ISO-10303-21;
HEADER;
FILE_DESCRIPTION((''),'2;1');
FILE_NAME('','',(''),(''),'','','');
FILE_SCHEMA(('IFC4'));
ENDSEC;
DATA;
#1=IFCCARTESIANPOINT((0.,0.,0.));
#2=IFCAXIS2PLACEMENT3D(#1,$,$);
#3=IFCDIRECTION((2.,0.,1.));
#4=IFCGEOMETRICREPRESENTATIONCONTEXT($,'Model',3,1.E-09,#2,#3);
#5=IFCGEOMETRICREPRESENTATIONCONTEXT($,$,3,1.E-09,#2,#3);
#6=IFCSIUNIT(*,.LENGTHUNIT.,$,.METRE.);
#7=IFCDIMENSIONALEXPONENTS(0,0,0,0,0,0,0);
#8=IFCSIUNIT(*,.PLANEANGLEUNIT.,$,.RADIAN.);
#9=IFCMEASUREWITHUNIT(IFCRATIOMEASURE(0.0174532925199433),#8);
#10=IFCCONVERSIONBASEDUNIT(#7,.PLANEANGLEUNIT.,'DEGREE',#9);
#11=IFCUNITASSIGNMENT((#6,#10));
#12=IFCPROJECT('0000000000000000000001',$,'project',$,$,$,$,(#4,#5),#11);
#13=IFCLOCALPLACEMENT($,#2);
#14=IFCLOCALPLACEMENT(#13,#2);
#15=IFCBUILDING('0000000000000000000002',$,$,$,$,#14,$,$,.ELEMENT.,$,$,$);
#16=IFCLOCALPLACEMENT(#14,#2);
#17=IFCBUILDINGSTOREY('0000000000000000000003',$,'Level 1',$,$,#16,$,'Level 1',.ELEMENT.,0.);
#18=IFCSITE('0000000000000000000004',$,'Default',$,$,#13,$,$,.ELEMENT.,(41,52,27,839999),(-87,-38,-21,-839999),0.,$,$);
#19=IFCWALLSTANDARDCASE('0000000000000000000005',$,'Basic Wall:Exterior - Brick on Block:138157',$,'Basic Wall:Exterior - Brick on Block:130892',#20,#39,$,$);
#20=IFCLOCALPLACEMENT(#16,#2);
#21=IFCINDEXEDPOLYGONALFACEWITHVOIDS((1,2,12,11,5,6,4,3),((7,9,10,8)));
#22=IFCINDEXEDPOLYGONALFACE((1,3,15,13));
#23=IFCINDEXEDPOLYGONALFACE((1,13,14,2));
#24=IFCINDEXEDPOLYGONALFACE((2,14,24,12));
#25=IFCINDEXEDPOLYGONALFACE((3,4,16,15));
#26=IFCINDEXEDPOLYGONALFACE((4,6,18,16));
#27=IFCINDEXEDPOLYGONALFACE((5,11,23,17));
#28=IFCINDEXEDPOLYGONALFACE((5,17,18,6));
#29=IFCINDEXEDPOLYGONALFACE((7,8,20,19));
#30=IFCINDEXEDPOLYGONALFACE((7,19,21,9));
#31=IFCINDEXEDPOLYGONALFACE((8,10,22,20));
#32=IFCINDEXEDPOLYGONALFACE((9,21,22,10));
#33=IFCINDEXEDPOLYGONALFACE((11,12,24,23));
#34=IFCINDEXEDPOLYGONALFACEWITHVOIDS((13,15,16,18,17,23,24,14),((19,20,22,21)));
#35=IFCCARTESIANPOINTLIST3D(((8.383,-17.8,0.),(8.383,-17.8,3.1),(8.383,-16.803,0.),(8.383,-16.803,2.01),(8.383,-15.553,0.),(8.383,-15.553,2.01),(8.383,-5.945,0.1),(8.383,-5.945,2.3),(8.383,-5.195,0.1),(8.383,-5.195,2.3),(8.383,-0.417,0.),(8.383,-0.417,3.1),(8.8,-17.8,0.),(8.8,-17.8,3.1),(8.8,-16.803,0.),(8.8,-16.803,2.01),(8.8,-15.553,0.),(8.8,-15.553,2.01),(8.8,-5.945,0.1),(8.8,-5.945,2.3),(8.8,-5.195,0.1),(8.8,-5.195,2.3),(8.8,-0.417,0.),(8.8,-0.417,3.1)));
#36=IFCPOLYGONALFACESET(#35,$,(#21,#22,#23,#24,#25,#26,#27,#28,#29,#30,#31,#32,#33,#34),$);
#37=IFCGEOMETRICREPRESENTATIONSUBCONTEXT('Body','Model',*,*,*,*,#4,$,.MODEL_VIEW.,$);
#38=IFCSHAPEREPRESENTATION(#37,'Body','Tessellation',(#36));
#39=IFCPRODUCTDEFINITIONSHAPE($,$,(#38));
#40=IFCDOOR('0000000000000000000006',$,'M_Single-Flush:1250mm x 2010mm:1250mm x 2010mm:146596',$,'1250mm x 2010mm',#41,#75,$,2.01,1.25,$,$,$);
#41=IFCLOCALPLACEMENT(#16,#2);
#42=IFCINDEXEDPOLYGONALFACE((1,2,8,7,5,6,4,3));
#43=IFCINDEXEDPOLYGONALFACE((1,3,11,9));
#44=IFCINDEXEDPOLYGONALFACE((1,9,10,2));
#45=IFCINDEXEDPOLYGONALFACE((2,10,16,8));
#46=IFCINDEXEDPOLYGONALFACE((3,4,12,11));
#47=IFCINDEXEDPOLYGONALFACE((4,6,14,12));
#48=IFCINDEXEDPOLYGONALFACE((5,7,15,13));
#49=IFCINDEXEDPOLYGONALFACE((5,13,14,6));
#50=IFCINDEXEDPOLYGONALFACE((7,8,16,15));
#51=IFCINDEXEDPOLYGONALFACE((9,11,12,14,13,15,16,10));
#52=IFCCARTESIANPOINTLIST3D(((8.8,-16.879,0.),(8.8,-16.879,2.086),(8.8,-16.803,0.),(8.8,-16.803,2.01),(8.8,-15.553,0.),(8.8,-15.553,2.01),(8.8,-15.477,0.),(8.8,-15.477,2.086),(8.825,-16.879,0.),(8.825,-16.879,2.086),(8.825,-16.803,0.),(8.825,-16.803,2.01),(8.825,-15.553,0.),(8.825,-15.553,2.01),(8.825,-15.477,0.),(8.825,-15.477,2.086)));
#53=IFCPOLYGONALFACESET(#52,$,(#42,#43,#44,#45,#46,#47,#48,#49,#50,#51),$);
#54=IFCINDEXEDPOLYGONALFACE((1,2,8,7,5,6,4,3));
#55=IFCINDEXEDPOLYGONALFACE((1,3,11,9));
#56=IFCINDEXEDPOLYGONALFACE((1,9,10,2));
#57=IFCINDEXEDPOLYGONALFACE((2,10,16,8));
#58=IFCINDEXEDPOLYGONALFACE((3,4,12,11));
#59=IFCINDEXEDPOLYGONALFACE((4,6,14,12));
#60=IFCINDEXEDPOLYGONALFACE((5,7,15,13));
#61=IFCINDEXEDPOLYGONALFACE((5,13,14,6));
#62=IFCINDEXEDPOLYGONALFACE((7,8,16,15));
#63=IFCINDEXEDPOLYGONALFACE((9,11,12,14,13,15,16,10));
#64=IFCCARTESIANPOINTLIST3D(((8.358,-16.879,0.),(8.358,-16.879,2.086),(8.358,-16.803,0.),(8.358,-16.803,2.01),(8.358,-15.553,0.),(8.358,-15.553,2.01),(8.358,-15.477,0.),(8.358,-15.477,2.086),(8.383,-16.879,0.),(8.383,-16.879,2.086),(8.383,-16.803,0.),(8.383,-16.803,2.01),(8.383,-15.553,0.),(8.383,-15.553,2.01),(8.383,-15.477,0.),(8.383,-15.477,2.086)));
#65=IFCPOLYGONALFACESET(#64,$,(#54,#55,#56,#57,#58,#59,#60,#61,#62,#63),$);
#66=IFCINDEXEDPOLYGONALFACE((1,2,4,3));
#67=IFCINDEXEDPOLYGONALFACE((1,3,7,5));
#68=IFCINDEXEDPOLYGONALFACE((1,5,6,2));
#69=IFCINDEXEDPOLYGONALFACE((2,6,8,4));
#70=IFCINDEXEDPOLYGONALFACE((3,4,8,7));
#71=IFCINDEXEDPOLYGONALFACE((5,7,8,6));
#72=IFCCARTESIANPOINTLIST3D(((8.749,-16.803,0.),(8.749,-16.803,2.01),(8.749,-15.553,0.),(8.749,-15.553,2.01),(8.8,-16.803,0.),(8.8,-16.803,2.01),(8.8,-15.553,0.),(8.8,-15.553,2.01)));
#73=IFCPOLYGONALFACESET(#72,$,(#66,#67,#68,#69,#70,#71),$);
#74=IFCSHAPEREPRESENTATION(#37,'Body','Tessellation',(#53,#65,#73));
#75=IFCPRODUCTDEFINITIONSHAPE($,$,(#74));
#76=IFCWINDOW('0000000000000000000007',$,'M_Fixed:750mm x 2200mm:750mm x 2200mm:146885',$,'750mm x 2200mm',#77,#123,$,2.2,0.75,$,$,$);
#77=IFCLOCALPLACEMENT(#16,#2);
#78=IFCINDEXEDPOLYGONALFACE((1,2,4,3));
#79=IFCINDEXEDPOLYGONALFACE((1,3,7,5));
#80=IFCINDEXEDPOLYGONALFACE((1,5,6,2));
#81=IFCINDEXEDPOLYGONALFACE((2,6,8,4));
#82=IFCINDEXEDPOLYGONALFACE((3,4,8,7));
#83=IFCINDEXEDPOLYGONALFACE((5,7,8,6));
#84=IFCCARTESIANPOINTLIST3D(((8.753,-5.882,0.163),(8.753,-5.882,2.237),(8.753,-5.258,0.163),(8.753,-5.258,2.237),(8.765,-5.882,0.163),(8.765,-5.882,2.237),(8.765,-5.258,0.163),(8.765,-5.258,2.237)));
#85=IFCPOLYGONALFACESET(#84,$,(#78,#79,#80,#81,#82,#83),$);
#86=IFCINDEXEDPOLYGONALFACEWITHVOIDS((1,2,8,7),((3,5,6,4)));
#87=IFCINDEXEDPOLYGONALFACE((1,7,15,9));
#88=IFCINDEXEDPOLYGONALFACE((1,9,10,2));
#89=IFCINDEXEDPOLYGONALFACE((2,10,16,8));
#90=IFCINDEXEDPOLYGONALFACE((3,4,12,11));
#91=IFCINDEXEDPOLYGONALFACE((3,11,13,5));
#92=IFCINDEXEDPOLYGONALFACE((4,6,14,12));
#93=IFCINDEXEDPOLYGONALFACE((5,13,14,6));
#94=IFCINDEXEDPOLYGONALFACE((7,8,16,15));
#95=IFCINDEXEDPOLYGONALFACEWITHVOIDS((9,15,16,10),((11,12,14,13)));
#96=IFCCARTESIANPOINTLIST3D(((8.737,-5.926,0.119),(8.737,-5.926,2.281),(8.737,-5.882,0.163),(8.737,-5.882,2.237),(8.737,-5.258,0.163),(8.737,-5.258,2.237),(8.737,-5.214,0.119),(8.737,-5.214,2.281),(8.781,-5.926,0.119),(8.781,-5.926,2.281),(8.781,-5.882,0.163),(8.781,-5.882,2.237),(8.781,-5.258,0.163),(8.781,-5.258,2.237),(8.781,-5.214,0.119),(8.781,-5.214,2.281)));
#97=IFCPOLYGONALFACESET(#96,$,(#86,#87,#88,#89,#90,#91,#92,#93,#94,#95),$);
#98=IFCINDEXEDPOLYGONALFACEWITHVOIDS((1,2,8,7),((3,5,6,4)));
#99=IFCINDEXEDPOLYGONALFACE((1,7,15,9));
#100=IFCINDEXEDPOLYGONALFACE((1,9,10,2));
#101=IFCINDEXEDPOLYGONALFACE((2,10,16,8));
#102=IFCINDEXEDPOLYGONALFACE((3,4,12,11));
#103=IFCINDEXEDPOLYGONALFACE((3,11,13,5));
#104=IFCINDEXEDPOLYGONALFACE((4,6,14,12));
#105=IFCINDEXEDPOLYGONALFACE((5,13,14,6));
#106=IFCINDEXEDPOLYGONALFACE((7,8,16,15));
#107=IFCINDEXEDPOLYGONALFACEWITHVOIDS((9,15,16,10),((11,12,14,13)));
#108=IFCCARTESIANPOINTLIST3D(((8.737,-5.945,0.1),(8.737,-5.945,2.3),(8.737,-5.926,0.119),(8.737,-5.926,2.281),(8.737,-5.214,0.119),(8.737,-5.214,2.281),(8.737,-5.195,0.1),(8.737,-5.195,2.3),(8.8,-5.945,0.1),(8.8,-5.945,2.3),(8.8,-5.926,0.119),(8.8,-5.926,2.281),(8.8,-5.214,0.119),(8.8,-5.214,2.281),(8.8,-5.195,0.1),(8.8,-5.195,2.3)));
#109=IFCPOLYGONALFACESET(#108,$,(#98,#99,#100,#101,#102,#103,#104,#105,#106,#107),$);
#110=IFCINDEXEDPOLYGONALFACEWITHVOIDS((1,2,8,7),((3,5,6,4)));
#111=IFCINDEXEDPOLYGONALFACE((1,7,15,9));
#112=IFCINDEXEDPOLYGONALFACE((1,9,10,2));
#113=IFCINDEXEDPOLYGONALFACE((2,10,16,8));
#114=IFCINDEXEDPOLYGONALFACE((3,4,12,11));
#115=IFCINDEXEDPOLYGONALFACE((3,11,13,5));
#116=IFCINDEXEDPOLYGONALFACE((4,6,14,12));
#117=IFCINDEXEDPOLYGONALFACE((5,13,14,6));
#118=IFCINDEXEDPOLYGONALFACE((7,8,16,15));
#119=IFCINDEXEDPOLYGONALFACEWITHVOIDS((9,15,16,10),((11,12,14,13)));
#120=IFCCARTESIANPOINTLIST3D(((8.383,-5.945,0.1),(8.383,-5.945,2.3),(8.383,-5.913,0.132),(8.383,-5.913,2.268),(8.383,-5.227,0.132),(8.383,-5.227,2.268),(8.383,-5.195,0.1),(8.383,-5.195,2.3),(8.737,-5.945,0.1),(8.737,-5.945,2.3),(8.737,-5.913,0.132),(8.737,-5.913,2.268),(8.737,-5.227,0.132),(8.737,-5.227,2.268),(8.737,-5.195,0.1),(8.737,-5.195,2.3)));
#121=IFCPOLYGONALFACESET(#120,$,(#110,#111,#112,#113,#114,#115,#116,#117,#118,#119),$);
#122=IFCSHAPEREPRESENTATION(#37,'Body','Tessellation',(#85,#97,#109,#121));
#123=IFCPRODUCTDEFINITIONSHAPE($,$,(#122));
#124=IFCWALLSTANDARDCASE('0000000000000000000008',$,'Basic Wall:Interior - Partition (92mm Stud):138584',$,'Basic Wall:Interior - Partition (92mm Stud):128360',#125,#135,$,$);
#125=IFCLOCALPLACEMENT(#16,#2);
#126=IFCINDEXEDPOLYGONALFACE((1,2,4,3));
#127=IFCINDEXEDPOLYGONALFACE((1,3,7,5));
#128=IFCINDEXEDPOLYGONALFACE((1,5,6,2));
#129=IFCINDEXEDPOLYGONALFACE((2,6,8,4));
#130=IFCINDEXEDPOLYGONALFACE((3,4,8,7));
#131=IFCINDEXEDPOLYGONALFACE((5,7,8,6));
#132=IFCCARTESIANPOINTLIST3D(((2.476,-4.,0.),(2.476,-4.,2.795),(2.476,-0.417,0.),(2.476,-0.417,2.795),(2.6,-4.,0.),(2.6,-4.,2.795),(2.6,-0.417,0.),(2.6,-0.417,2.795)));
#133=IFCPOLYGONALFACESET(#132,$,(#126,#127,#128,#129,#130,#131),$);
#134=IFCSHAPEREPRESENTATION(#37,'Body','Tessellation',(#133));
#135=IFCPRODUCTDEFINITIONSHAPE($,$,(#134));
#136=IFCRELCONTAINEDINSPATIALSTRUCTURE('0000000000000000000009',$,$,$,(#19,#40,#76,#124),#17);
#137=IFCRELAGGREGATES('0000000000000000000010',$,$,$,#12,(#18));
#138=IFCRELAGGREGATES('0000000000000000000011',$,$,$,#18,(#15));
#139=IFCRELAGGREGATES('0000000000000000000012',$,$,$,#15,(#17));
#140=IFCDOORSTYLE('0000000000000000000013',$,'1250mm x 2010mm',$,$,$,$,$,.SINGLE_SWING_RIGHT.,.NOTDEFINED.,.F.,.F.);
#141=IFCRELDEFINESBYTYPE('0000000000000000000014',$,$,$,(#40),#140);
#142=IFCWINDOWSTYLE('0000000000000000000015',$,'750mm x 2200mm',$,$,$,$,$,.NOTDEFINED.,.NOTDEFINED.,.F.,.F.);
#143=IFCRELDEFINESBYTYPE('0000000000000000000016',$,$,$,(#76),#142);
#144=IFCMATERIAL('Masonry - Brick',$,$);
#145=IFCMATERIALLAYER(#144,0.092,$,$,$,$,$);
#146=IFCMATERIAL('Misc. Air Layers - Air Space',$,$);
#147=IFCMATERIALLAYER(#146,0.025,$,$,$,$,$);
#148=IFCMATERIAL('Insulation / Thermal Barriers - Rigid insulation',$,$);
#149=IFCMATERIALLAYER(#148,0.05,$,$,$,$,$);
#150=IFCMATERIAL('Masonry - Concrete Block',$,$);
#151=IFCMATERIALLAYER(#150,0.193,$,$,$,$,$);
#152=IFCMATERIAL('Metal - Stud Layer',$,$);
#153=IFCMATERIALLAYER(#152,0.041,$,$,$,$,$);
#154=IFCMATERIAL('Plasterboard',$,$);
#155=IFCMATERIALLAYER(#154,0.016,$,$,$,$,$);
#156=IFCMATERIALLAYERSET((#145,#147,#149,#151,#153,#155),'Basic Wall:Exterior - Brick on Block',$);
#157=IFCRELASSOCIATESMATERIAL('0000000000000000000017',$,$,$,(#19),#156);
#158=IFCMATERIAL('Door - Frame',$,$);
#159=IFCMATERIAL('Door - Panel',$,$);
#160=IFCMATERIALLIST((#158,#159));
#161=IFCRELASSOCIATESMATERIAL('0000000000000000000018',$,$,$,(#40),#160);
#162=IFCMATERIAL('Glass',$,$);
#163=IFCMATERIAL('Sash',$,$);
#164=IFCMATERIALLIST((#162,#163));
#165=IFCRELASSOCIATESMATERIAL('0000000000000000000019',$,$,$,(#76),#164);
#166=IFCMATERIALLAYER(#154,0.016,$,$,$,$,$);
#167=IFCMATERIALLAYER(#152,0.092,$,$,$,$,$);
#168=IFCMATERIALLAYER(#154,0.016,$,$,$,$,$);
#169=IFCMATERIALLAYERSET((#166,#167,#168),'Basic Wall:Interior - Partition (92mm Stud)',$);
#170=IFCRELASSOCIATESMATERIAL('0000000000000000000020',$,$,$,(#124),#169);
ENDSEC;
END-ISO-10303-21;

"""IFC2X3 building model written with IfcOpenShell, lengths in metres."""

from ifc_helpers import new_model, entity, si_unit, converted_unit, direction, frame, frame_2d, origin, origin_2d_with_axis, place, context, subcontext, project, spatial, polyline, rectangle, outline, extrude, source, transform, mapped, material, material_list, layer, layer_set, layer_usage, type_object, type_shapes, element, fill, save


model = new_model("IFC2X3")

# Units and contexts
model_context = context("Model", 3, precision=1e-09, world=origin(), true_north=direction((2.0, 0.0, 1.0)))
context_of_model = context(None, 3, precision=1e-09, world=origin(), true_north=direction((2.0, 0.0, 1.0)))
body_context = subcontext(model_context, "Body", "Model", "MODEL_VIEW")
ifc_project = project(units=[si_unit("LENGTHUNIT", "METRE"), converted_unit("PLANEANGLEUNIT", "DEGREE", entity("IfcRatioMeasure", 0.0174532925199433), si_unit("PLANEANGLEUNIT", "RADIAN"), dimensions=[0, 0, 0, 0, 0, 0, 0])], contexts=[model_context, context_of_model])

# Site, building, storey
site_placement = place(None, origin())
site = spatial("IfcSite", under=ifc_project, at=site_placement, Name="Default", CompositionType="ELEMENT", RefLatitude=(41, 52, 27, 839999), RefLongitude=(-87, -38, -21, -839999), RefElevation=0.0)
building_placement = place(site_placement, origin())
building = spatial("IfcBuilding", under=site, at=building_placement, CompositionType="ELEMENT")
storey_placement = place(building_placement, origin())
storey = spatial("IfcBuildingStorey", under=building, at=storey_placement, Name="Level 1", LongName="Level 1", CompositionType="ELEMENT", Elevation=0.0)

# Shared definitions
ifc_material_1 = material(Name="Masonry - Brick")
ifc_layer_1 = layer(ifc_material_1, 0.092)
ifc_material_2 = material(Name="Misc. Air Layers - Air Space")
ifc_layer_2 = layer(ifc_material_2, 0.025)
ifc_material_3 = material(Name="Insulation / Thermal Barriers - Rigid insulation")
ifc_layer_3 = layer(ifc_material_3, 0.05)
ifc_material_4 = material(Name="Masonry - Concrete Block")
ifc_layer_4 = layer(ifc_material_4, 0.193)
ifc_material_5 = material(Name="Metal - Stud Layer")
ifc_layer_5 = layer(ifc_material_5, 0.041)
ifc_material_6 = material(Name="Plasterboard")
ifc_layer_6 = layer(ifc_material_6, 0.016)
ifc_layer_set_1 = layer_set([ifc_layer_1, ifc_layer_2, ifc_layer_3, ifc_layer_4, ifc_layer_5, ifc_layer_6], Name="Basic Wall:Exterior - Brick on Block")
ifc_material_7 = material(Name="Glass")
ifc_material_8 = material(Name="Sash")
ifc_material_9 = material(Name="Door - Frame")
ifc_material_10 = material(Name="Door - Panel")

# Wall, openings, door, window
ifc_layer_usage_1 = layer_usage(ifc_layer_set_1, "AXIS2", "NEGATIVE", 0.2085)
wall_1_placement = place(storey_placement, frame((8.5915, -0.417, 0.0), z_axis=(0.0, 0.0, 1.0), x_axis=(0.0, -1.0, 0.0)))
wall_1 = element("IfcWallStandardCase", 1, at=wall_1_placement, inside=storey, material=ifc_layer_usage_1, Name="Basic Wall:Exterior - Brick on Block:138157", ObjectType="Basic Wall:Exterior - Brick on Block:130892", context=body_context, shape_type="SweptSolid", body=[
    extrude(rectangle(XDim=17.383, YDim=0.417, at=frame_2d((8.6915, 0.0), x_axis=(-1.0, 0.0))), origin(), (0.0, 0.0, 1.0), 3.1),
])
opening_1_placement = place(wall_1_placement, frame((15.136, -0.2085, 0.0)))
opening_1 = element("IfcOpeningElement", 2, at=opening_1_placement, cuts=wall_1, ObjectType="Opening", context=body_context, shape_type="SweptSolid", body=[
    extrude(rectangle(XDim=1.25, YDim=2.01, at=frame_2d((1.005, 0.625), x_axis=(0.0, 1.0))), frame((0.0, 0.0, 0.0), z_axis=(0.0, 1.0, 0.0), x_axis=(0.0, 0.0, 1.0)), (0.0, 0.0, 1.0), 0.417),
])
opening_2_placement = place(wall_1_placement, frame((4.778, -0.2085, 0.1)))
opening_2 = element("IfcOpeningElement", 3, at=opening_2_placement, cuts=wall_1, ObjectType="Opening", context=body_context, shape_type="SweptSolid", body=[
    extrude(rectangle(XDim=2.2, YDim=0.75, at=frame_2d((1.1, 0.375), x_axis=(1.0, 0.0))), frame((0.0, 0.0, 0.0), z_axis=(0.0, 1.0, 0.0), x_axis=(0.0, 0.0, 1.0)), (0.0, 0.0, 1.0), 0.417),
])
ifc_material_list_1 = material_list([ifc_material_9, ifc_material_10])
door_style_1 = type_object("IfcDoorStyle", Name="1250mm x 2010mm", ConstructionType="NOTDEFINED", OperationType="SINGLE_SWING_RIGHT", ParameterTakesPrecedence=False, Sizeable=False)
shared_shape_1 = source(origin(), body_context, "Body", "SweptSolid", [
    extrude(outline(polyline([(-0.701, -1.062), (0.701, -1.062), (0.701, 1.024), (0.625, 1.024), (0.625, -0.986), (-0.625, -0.986), (-0.625, 1.024), (-0.701, 1.024), (-0.701, -1.062)])), frame((0.625, 0.417, 1.024), z_axis=(0.0, 1.0, 0.0), x_axis=(1.0, 0.0, 0.0)), (0.0, 0.0, 1.0), 0.025),
    extrude(outline(polyline([(-1.062, -0.701), (1.024, -0.701), (1.024, -0.625), (-0.986, -0.625), (-0.986, 0.625), (1.024, 0.625), (1.024, 0.701), (-1.062, 0.701), (-1.062, -0.701)])), frame((0.625, -0.025, 1.024), z_axis=(0.0, 1.0, 0.0), x_axis=(0.0, 0.0, -1.0)), (0.0, 0.0, 1.0), 0.025),
    extrude(rectangle(XDim=0.051, YDim=1.25, at=frame_2d((0.0, 0.0), x_axis=(1.0, 0.0))), frame((0.625, 0.3915, 0.0), z_axis=(0.0, 0.0, 1.0), x_axis=(0.0, 1.0, 0.0)), (0.0, 0.0, 1.0), 2.01),
])
type_shapes(door_style_1, [shared_shape_1])
door_1_placement = place(opening_1_placement, origin())
door_1 = element("IfcDoor", 4, at=door_1_placement, inside=storey, type_object=door_style_1, material=ifc_material_list_1, Name="M_Single-Flush:1250mm x 2010mm:1250mm x 2010mm:146596", ObjectType="1250mm x 2010mm", OverallHeight=2.01, OverallWidth=1.25, context=body_context, shape_type="MappedRepresentation", body=[
    mapped(shared_shape_1, transform((0.0, 0.0, 0.0), scale=1.0)),
])
fill(opening_1, door_1)
ifc_material_list_2 = material_list([ifc_material_7, ifc_material_8])
window_style_1 = type_object("IfcWindowStyle", Name="750mm x 2200mm", ConstructionType="NOTDEFINED", OperationType="NOTDEFINED", ParameterTakesPrecedence=False, Sizeable=False)
shared_shape_2 = source(origin(), body_context, "Body", "SweptSolid", [
    extrude(rectangle(XDim=0.012, YDim=0.624, at=origin_2d_with_axis()), frame((0.375, 0.376, 0.063), z_axis=(0.0, 0.0, 1.0), x_axis=(0.0, -1.0, 0.0)), (0.0, 0.0, 1.0), 2.074),
    extrude(outline(polyline([(-0.356, -1.081), (0.356, -1.081), (0.356, 1.081), (-0.356, 1.081), (-0.356, -1.081)]), holes=[polyline([(-0.312, -1.037), (-0.312, 1.037), (0.312, 1.037), (0.312, -1.037), (-0.312, -1.037)])]), frame((0.375, 0.354, 1.1), z_axis=(0.0, 1.0, 0.0), x_axis=(1.0, 0.0, 0.0)), (0.0, 0.0, 1.0), 0.044),
    extrude(outline(polyline([(-0.375, -1.1), (0.375, -1.1), (0.375, 1.1), (-0.375, 1.1), (-0.375, -1.1)]), holes=[polyline([(-0.356, -1.081), (-0.356, 1.081), (0.356, 1.081), (0.356, -1.081), (-0.356, -1.081)])]), frame((0.375, 0.354, 1.1), z_axis=(0.0, 1.0, 0.0), x_axis=(1.0, 0.0, 0.0)), (0.0, 0.0, 1.0), 0.063),
    extrude(outline(polyline([(-0.375, -1.1), (0.375, -1.1), (0.375, 1.1), (-0.375, 1.1), (-0.375, -1.1)]), holes=[polyline([(-0.343, -1.068), (-0.343, 1.068), (0.343, 1.068), (0.343, -1.068), (-0.343, -1.068)])]), frame((0.375, 0.0, 1.1), z_axis=(0.0, 1.0, 0.0), x_axis=(1.0, 0.0, 0.0)), (0.0, 0.0, 1.0), 0.354),
])
type_shapes(window_style_1, [shared_shape_2])
window_1_placement = place(opening_2_placement, origin())
window_1 = element("IfcWindow", 5, at=window_1_placement, inside=storey, type_object=window_style_1, material=ifc_material_list_2, Name="M_Fixed:750mm x 2200mm:750mm x 2200mm:146885", ObjectType="750mm x 2200mm", OverallHeight=2.2, OverallWidth=0.75, context=body_context, shape_type="MappedRepresentation", body=[
    mapped(shared_shape_2, transform((0.0, 0.0, 0.0), scale=1.0)),
])
fill(opening_2, window_1)

# Wall
ifc_layer_7 = layer(ifc_material_6, 0.016)
ifc_layer_8 = layer(ifc_material_5, 0.092)
ifc_layer_9 = layer(ifc_material_6, 0.016)
ifc_layer_set_2 = layer_set([ifc_layer_7, ifc_layer_8, ifc_layer_9], Name="Basic Wall:Interior - Partition (92mm Stud)")
ifc_layer_usage_2 = layer_usage(ifc_layer_set_2, "AXIS2", "NEGATIVE", 0.062)
wall_2_placement = place(storey_placement, frame((2.538, -0.417, 0.0), z_axis=(0.0, 0.0, 1.0), x_axis=(0.0, -1.0, 0.0)))
element("IfcWallStandardCase", 6, at=wall_2_placement, inside=storey, material=ifc_layer_usage_2, Name="Basic Wall:Interior - Partition (92mm Stud):138584", ObjectType="Basic Wall:Interior - Partition (92mm Stud):128360", context=body_context, shape_type="SweptSolid", body=[
    extrude(rectangle(XDim=3.583, YDim=0.124, at=frame_2d((1.7915, 0.0), x_axis=(-1.0, 0.0))), origin(), (0.0, 0.0, 1.0), 2.795),
])

save(model, "model.ifc")
